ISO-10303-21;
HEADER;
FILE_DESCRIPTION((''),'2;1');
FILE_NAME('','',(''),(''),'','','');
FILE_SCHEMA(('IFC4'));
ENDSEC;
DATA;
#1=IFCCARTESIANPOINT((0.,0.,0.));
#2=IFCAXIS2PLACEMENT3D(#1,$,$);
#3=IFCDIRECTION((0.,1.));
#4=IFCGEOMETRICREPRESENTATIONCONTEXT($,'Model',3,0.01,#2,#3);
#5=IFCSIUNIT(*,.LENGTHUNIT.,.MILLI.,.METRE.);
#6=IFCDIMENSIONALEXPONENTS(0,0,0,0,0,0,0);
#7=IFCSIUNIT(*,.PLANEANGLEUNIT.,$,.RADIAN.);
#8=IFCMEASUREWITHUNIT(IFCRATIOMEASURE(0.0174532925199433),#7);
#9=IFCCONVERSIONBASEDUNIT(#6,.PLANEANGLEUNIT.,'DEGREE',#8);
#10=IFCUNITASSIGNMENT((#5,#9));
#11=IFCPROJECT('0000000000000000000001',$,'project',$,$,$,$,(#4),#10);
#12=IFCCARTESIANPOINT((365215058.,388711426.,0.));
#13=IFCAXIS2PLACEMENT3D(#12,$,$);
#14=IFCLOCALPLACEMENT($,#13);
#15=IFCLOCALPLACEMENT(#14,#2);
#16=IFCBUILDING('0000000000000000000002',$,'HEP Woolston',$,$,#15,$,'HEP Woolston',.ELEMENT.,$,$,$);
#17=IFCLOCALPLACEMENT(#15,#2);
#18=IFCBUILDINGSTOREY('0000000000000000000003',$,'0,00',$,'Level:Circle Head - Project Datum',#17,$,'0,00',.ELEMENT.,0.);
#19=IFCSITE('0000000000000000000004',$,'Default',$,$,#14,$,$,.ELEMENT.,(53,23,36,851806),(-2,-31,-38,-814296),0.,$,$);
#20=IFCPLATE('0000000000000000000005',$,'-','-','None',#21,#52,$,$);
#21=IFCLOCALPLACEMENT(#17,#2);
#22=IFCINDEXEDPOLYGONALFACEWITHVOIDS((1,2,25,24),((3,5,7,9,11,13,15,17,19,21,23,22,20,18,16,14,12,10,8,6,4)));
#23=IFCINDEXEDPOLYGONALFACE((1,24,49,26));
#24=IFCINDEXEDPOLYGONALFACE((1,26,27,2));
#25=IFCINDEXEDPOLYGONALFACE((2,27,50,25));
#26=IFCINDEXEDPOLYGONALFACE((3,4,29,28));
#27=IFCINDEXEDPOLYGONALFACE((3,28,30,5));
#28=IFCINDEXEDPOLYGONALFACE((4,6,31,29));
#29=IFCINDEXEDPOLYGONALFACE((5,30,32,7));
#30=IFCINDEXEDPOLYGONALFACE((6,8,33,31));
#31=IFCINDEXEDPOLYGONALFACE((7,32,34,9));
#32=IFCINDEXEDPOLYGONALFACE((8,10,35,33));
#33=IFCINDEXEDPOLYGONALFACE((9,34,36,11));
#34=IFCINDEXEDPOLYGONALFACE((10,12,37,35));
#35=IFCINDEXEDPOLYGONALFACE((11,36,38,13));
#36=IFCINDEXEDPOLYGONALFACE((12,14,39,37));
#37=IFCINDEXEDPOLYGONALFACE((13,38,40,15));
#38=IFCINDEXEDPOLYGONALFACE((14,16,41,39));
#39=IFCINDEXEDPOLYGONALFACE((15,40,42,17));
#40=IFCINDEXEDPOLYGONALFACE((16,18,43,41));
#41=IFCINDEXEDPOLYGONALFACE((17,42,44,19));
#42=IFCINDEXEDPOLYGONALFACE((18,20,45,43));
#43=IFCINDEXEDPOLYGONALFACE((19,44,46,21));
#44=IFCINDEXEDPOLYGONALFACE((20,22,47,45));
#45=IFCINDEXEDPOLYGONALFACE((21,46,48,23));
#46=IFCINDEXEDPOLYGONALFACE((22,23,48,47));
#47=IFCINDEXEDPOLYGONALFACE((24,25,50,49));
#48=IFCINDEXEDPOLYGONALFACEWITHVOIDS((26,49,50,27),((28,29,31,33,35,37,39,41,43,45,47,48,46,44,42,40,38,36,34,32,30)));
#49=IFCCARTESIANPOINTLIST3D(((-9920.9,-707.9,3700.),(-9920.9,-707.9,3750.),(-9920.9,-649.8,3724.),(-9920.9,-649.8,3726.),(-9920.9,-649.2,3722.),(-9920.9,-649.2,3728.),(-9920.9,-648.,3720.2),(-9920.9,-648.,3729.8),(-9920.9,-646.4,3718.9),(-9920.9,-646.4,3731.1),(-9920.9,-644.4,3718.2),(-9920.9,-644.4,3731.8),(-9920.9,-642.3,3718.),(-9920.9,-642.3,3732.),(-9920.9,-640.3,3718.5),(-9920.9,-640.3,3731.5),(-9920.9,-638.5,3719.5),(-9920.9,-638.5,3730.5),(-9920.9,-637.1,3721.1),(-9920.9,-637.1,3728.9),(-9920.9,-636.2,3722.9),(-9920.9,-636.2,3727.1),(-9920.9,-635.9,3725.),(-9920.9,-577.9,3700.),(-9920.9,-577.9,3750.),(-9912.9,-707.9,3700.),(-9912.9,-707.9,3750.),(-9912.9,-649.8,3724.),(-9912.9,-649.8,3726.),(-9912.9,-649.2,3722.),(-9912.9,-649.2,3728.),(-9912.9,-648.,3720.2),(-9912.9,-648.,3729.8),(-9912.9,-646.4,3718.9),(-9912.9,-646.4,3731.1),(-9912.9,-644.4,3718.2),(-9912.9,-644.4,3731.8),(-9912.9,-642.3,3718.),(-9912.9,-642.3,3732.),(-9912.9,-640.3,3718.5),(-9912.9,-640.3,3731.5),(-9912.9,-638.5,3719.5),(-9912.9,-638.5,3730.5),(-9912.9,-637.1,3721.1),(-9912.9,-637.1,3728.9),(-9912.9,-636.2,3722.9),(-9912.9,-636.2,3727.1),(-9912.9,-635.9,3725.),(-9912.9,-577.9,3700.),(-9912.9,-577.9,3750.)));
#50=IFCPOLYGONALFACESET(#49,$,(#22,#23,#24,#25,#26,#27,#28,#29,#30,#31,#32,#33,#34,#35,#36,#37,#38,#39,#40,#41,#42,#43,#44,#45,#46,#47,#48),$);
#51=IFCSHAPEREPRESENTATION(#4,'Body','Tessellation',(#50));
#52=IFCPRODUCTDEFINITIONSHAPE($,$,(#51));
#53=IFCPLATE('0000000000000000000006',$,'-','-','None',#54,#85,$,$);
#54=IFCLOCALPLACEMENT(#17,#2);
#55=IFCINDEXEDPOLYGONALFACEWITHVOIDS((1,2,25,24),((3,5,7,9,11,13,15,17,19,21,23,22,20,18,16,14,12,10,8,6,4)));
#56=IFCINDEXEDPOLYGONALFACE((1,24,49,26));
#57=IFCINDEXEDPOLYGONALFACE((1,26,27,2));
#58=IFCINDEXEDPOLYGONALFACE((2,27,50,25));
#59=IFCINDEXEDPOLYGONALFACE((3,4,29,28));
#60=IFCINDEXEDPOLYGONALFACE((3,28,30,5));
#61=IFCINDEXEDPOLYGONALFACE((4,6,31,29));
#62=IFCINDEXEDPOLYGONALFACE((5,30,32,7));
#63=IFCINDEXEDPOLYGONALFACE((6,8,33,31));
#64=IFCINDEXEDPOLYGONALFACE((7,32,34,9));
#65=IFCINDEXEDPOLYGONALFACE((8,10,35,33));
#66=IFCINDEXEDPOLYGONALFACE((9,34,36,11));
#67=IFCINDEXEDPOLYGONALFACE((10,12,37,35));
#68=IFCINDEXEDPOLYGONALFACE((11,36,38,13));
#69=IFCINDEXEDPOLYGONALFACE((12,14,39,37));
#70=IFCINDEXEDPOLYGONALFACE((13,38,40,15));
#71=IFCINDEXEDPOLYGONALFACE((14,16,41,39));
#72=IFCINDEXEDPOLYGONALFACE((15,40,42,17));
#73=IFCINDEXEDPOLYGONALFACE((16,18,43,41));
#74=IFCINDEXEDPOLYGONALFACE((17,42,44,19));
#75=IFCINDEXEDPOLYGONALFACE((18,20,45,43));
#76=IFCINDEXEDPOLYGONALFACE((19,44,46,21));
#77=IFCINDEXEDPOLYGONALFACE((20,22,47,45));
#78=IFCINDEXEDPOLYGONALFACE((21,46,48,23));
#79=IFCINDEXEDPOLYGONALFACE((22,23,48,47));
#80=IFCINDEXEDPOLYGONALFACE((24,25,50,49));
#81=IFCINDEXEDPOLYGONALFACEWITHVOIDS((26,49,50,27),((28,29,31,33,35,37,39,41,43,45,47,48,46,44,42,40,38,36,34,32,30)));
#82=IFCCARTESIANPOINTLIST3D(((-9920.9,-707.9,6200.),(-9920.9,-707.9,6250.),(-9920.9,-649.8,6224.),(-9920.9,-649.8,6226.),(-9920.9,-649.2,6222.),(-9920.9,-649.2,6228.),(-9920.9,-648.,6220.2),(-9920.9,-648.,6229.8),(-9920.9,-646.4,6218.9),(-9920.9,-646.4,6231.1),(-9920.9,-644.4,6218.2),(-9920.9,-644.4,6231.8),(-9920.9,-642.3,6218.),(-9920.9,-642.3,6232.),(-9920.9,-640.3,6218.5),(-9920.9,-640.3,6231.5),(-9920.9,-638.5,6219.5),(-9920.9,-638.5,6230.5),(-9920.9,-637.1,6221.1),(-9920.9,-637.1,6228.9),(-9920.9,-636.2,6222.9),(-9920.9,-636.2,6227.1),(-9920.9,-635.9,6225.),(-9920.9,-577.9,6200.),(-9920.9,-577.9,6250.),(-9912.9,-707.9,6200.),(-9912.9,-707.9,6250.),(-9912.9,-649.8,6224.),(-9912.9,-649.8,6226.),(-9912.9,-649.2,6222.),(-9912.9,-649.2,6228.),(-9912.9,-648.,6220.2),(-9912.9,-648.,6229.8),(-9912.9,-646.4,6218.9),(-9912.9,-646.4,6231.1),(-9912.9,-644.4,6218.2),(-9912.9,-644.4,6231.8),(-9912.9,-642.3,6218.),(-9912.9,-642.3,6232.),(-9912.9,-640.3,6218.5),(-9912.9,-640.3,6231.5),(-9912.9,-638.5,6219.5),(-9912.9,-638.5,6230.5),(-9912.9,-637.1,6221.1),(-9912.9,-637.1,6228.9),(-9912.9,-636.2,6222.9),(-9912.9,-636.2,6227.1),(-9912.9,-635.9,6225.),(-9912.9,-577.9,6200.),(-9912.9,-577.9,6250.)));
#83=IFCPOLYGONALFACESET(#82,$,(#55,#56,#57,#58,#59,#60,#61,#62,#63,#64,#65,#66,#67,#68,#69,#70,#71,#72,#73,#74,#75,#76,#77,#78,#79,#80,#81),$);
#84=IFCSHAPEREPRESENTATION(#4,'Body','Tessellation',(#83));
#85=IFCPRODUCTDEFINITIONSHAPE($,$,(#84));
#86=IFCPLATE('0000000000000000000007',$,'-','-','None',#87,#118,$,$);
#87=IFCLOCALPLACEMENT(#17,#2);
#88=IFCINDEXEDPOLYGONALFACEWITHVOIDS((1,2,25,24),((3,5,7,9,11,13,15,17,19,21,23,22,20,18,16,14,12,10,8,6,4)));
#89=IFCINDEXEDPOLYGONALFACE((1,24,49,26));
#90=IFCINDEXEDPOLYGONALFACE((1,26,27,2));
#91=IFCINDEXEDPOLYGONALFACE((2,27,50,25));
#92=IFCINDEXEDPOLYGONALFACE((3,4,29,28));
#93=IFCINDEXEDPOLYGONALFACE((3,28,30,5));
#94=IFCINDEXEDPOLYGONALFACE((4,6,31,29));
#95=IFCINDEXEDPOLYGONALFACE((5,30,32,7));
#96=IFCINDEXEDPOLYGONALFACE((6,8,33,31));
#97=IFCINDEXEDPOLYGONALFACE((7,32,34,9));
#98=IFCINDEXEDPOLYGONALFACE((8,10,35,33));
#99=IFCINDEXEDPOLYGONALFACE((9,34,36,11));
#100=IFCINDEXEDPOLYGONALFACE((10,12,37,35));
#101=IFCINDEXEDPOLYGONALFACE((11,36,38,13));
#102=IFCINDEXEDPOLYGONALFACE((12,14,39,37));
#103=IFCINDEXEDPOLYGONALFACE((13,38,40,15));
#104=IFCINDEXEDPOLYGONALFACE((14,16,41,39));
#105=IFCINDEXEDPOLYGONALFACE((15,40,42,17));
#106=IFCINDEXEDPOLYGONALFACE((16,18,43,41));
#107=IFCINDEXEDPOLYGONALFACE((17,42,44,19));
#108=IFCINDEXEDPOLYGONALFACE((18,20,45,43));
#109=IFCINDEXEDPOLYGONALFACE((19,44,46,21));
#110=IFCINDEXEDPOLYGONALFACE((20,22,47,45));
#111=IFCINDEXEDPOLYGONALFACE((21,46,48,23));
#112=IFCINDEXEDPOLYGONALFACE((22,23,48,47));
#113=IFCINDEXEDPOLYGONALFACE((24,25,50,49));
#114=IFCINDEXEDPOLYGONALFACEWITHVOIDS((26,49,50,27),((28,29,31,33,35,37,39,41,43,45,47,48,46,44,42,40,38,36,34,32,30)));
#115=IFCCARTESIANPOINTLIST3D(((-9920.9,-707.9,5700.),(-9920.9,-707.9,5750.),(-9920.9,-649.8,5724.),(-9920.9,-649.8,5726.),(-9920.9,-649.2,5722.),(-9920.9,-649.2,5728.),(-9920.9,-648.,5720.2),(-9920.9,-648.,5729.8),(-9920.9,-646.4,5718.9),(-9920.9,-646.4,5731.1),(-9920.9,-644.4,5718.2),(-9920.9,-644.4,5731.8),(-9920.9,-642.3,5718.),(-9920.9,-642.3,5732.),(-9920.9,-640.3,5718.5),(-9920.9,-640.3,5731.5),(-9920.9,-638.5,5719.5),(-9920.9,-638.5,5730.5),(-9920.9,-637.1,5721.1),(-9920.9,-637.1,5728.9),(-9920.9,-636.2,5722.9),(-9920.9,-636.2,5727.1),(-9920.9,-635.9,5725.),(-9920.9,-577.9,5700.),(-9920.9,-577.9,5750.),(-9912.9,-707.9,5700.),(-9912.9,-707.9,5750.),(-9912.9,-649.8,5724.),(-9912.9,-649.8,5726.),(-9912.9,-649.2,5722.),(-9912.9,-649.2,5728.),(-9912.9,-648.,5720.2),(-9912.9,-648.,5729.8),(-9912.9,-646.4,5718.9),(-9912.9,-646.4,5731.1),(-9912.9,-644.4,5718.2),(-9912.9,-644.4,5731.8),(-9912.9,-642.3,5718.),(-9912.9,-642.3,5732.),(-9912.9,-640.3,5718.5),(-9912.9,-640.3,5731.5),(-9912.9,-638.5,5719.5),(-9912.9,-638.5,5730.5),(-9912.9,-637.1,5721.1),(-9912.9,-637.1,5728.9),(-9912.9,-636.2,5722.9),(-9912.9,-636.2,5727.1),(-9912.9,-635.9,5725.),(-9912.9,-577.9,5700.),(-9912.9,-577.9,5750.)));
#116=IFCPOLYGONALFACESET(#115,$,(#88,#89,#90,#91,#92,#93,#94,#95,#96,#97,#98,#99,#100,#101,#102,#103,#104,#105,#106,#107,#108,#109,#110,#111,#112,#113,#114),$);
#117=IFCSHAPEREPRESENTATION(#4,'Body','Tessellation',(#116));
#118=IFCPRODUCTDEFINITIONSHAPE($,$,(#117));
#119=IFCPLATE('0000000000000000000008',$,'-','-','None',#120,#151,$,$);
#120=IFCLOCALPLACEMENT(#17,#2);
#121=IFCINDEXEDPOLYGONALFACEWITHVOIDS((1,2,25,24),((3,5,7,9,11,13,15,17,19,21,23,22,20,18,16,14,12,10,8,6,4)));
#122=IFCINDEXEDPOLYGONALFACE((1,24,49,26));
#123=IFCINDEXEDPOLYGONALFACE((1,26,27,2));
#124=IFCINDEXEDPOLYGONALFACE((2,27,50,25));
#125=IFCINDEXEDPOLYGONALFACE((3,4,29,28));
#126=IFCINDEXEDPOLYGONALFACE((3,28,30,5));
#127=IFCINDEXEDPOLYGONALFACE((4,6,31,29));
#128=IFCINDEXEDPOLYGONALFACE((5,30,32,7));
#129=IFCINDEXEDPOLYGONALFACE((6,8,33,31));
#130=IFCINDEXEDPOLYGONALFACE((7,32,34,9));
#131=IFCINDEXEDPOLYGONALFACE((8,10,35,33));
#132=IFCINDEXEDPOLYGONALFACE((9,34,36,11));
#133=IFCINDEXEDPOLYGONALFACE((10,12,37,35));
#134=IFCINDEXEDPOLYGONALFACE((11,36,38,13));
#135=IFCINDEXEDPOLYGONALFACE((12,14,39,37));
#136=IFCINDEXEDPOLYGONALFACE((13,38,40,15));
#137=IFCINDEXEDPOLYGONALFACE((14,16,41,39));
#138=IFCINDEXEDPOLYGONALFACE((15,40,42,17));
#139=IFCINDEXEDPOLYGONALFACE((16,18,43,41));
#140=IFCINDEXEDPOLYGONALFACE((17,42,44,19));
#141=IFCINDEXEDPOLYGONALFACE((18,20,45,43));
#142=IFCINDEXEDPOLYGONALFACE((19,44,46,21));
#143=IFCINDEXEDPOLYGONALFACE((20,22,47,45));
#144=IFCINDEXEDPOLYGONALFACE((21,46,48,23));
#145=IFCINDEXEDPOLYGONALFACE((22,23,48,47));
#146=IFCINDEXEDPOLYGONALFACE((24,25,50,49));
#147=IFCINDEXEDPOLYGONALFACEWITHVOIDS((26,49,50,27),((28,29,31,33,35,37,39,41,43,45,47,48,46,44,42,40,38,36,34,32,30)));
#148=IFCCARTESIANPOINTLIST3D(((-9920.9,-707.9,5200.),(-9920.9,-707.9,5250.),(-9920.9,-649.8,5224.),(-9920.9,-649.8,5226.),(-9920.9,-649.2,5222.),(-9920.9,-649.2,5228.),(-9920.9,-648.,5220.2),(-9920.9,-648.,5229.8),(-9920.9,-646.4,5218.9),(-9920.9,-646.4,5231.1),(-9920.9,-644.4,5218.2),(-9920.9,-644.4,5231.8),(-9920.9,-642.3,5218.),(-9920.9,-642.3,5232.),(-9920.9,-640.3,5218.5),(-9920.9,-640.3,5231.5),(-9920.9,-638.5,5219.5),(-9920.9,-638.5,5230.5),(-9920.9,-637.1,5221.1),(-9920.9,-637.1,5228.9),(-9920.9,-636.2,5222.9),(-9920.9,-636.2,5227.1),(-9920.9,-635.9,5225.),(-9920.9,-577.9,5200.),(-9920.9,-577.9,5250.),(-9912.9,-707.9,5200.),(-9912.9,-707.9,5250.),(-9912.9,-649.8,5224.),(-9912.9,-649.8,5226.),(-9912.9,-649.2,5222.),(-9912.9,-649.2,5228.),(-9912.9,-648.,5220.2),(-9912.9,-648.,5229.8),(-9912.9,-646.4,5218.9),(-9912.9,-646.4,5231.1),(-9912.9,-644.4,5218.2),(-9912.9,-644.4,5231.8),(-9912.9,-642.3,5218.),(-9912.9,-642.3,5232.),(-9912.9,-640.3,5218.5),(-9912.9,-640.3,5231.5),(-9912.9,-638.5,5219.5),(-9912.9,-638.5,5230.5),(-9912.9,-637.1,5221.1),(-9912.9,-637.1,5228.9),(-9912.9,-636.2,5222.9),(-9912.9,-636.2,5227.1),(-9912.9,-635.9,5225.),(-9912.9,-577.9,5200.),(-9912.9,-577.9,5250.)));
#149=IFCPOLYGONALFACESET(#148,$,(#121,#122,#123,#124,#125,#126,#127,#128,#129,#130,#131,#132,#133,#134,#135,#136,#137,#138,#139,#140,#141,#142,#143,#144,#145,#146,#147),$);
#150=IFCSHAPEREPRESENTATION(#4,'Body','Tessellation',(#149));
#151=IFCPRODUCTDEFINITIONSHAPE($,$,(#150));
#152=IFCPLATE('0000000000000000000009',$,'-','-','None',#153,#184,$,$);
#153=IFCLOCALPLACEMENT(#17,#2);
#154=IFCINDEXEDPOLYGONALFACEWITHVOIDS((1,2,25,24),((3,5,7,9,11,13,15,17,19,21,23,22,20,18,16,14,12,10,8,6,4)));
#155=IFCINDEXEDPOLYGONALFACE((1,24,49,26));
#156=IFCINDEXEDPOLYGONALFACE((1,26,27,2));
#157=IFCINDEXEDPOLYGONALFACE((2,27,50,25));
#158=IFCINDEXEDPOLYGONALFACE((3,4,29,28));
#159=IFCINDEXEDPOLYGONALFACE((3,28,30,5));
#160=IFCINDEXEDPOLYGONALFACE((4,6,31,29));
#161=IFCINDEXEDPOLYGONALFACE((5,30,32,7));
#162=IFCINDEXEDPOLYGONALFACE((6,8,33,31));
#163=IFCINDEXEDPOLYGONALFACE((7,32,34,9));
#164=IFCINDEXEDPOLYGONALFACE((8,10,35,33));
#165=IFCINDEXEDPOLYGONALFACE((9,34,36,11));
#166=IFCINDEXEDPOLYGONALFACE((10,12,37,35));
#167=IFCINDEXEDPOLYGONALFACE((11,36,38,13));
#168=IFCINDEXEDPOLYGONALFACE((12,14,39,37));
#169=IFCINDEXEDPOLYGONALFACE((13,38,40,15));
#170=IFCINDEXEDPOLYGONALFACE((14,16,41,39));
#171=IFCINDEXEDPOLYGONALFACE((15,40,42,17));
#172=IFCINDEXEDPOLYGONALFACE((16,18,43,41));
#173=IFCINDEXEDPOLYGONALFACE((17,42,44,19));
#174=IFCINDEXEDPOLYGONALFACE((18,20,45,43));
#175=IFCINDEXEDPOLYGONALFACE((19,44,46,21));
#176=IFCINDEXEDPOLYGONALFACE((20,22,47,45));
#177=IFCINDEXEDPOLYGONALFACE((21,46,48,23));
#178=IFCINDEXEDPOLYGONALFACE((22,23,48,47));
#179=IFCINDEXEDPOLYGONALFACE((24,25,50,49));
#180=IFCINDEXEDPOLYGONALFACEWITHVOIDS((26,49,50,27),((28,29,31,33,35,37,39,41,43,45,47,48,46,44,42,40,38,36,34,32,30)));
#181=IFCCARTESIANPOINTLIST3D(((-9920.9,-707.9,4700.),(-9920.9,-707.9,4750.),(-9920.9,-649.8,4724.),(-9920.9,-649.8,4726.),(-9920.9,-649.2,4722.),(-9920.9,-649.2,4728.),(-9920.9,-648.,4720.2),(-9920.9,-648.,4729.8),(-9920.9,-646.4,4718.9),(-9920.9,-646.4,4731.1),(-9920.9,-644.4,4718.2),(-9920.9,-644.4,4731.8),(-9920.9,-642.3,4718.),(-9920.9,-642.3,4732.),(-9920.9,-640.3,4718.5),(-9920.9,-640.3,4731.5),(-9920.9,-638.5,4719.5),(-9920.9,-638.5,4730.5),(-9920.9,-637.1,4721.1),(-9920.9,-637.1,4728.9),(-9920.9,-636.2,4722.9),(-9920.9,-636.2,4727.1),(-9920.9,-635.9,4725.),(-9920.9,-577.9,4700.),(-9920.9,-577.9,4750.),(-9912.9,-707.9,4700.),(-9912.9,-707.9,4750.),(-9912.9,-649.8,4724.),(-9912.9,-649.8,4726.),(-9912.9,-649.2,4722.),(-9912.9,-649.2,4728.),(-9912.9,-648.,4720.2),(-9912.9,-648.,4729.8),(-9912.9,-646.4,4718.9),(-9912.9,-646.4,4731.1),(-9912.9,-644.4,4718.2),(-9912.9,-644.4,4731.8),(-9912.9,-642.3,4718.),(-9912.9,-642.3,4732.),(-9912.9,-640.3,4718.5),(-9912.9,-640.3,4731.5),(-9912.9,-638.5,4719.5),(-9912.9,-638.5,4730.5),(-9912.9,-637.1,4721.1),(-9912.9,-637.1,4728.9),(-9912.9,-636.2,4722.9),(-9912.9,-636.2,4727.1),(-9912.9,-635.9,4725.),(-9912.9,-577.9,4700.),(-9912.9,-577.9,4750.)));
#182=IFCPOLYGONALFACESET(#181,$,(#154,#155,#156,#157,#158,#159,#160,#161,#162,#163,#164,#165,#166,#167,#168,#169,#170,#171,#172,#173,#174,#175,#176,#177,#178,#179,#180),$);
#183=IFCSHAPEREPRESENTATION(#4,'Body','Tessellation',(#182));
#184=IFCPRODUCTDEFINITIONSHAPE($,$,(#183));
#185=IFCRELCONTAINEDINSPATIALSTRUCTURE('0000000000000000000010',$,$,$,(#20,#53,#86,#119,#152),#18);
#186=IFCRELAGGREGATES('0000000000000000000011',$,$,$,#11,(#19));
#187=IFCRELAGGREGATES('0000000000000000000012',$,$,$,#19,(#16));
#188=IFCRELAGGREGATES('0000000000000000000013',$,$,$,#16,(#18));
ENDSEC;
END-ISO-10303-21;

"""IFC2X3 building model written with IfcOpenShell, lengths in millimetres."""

from ifc_helpers import new_model, entity, si_unit, converted_unit, direction, frame, origin, origin_with_axes, origin_2d_with_axis, place, context, project, spatial, polyline, circle, outline, extrude, element, save


model = new_model("IFC2X3")

# Units and contexts
model_context = context("Model", 3, precision=0.01, world=origin(), true_north=direction((0.0, 1.0)))
ifc_project = project(units=[si_unit("LENGTHUNIT", "METRE", prefix="MILLI"), converted_unit("PLANEANGLEUNIT", "DEGREE", entity("IfcRatioMeasure", 0.0174532925199433), si_unit("PLANEANGLEUNIT", "RADIAN"), dimensions=[0, 0, 0, 0, 0, 0, 0])], contexts=[model_context])

# Site, building, storey
site_placement = place(None, frame((365215058.0, 388711426.0, 0.0)))
site = spatial("IfcSite", under=ifc_project, at=site_placement, Name="Default", CompositionType="ELEMENT", RefLatitude=(53, 23, 36, 851806), RefLongitude=(-2, -31, -38, -814296), RefElevation=0.0)
building_placement = place(site_placement, origin())
building = spatial("IfcBuilding", under=site, at=building_placement, Name="HEP Woolston", LongName="HEP Woolston", CompositionType="ELEMENT")
storey_placement = place(building_placement, origin())
storey = spatial("IfcBuildingStorey", under=building, at=storey_placement, Name="0,00", ObjectType="Level:Circle Head - Project Datum", LongName="0,00", CompositionType="ELEMENT", Elevation=0.0)

# Plates, openings
plate_1_placement = place(storey_placement, frame((-9920.9, -707.9, 3750.0), z_axis=(1.0, 0.0, 0.0), x_axis=(0.0, 1.0, 0.0)))
plate_1 = element("IfcPlate", 1, at=plate_1_placement, inside=storey, Name="-", Description="-", ObjectType="None", context=model_context, shape_type="SweptSolid", body=[
    extrude(outline(polyline([(0.0, -50.0), (130.0, -50.0), (130.0, 0.0), (0.0, 0.0), (0.0, -50.0)])), origin_with_axes(), (0.0, 0.0, 1.0), 8.0),
])
opening_1_placement = place(plate_1_placement, frame((65.0, -25.0, 8.5), z_axis=(0.0, 0.0, -1.0), x_axis=(1.0, 0.0, 0.0)))
element("IfcOpeningElement", 2, at=opening_1_placement, cuts=plate_1, ObjectType="Opening", context=model_context, shape_type="SweptSolid", body=[
    extrude(circle(Radius=7.0, at=origin_2d_with_axis()), origin(), (0.0, 0.0, 1.0), 9.0),
])
plate_2_placement = place(storey_placement, frame((-9920.9, -707.9, 6250.0), z_axis=(1.0, 0.0, 0.0), x_axis=(0.0, 1.0, 0.0)))
plate_2 = element("IfcPlate", 3, at=plate_2_placement, inside=storey, Name="-", Description="-", ObjectType="None", context=model_context, shape_type="SweptSolid", body=[
    extrude(outline(polyline([(0.0, -50.0), (130.0, -50.0), (130.0, 0.0), (0.0, 0.0), (0.0, -50.0)])), origin_with_axes(), (0.0, 0.0, 1.0), 8.0),
])
opening_2_placement = place(plate_2_placement, frame((65.0, -25.0, 8.5), z_axis=(0.0, 0.0, -1.0), x_axis=(1.0, 0.0, 0.0)))
element("IfcOpeningElement", 4, at=opening_2_placement, cuts=plate_2, ObjectType="Opening", context=model_context, shape_type="SweptSolid", body=[
    extrude(circle(Radius=7.0, at=origin_2d_with_axis()), origin(), (0.0, 0.0, 1.0), 9.0),
])
plate_3_placement = place(storey_placement, frame((-9920.9, -707.9, 5750.0), z_axis=(1.0, 0.0, 0.0), x_axis=(0.0, 1.0, 0.0)))
plate_3 = element("IfcPlate", 5, at=plate_3_placement, inside=storey, Name="-", Description="-", ObjectType="None", context=model_context, shape_type="SweptSolid", body=[
    extrude(outline(polyline([(0.0, -50.0), (130.0, -50.0), (130.0, 0.0), (0.0, 0.0), (0.0, -50.0)])), origin_with_axes(), (0.0, 0.0, 1.0), 8.0),
])
opening_3_placement = place(plate_3_placement, frame((65.0, -25.0, 8.5), z_axis=(0.0, 0.0, -1.0), x_axis=(1.0, 0.0, 0.0)))
element("IfcOpeningElement", 6, at=opening_3_placement, cuts=plate_3, ObjectType="Opening", context=model_context, shape_type="SweptSolid", body=[
    extrude(circle(Radius=7.0, at=origin_2d_with_axis()), origin(), (0.0, 0.0, 1.0), 9.0),
])
plate_4_placement = place(storey_placement, frame((-9920.9, -707.9, 5250.0), z_axis=(1.0, 0.0, 0.0), x_axis=(0.0, 1.0, 0.0)))
plate_4 = element("IfcPlate", 7, at=plate_4_placement, inside=storey, Name="-", Description="-", ObjectType="None", context=model_context, shape_type="SweptSolid", body=[
    extrude(outline(polyline([(0.0, -50.0), (130.0, -50.0), (130.0, 0.0), (0.0, 0.0), (0.0, -50.0)])), origin_with_axes(), (0.0, 0.0, 1.0), 8.0),
])
opening_4_placement = place(plate_4_placement, frame((65.0, -25.0, 8.5), z_axis=(0.0, 0.0, -1.0), x_axis=(1.0, 0.0, 0.0)))
element("IfcOpeningElement", 8, at=opening_4_placement, cuts=plate_4, ObjectType="Opening", context=model_context, shape_type="SweptSolid", body=[
    extrude(circle(Radius=7.0, at=origin_2d_with_axis()), origin(), (0.0, 0.0, 1.0), 9.0),
])
plate_5_placement = place(storey_placement, frame((-9920.9, -707.9, 4750.0), z_axis=(1.0, 0.0, 0.0), x_axis=(0.0, 1.0, 0.0)))
plate_5 = element("IfcPlate", 9, at=plate_5_placement, inside=storey, Name="-", Description="-", ObjectType="None", context=model_context, shape_type="SweptSolid", body=[
    extrude(outline(polyline([(0.0, -50.0), (130.0, -50.0), (130.0, 0.0), (0.0, 0.0), (0.0, -50.0)])), origin_with_axes(), (0.0, 0.0, 1.0), 8.0),
])
opening_5_placement = place(plate_5_placement, frame((65.0, -25.0, 8.5), z_axis=(0.0, 0.0, -1.0), x_axis=(1.0, 0.0, 0.0)))
element("IfcOpeningElement", 10, at=opening_5_placement, cuts=plate_5, ObjectType="Opening", context=model_context, shape_type="SweptSolid", body=[
    extrude(circle(Radius=7.0, at=origin_2d_with_axis()), origin(), (0.0, 0.0, 1.0), 9.0),
])

save(model, "model.ifc")
